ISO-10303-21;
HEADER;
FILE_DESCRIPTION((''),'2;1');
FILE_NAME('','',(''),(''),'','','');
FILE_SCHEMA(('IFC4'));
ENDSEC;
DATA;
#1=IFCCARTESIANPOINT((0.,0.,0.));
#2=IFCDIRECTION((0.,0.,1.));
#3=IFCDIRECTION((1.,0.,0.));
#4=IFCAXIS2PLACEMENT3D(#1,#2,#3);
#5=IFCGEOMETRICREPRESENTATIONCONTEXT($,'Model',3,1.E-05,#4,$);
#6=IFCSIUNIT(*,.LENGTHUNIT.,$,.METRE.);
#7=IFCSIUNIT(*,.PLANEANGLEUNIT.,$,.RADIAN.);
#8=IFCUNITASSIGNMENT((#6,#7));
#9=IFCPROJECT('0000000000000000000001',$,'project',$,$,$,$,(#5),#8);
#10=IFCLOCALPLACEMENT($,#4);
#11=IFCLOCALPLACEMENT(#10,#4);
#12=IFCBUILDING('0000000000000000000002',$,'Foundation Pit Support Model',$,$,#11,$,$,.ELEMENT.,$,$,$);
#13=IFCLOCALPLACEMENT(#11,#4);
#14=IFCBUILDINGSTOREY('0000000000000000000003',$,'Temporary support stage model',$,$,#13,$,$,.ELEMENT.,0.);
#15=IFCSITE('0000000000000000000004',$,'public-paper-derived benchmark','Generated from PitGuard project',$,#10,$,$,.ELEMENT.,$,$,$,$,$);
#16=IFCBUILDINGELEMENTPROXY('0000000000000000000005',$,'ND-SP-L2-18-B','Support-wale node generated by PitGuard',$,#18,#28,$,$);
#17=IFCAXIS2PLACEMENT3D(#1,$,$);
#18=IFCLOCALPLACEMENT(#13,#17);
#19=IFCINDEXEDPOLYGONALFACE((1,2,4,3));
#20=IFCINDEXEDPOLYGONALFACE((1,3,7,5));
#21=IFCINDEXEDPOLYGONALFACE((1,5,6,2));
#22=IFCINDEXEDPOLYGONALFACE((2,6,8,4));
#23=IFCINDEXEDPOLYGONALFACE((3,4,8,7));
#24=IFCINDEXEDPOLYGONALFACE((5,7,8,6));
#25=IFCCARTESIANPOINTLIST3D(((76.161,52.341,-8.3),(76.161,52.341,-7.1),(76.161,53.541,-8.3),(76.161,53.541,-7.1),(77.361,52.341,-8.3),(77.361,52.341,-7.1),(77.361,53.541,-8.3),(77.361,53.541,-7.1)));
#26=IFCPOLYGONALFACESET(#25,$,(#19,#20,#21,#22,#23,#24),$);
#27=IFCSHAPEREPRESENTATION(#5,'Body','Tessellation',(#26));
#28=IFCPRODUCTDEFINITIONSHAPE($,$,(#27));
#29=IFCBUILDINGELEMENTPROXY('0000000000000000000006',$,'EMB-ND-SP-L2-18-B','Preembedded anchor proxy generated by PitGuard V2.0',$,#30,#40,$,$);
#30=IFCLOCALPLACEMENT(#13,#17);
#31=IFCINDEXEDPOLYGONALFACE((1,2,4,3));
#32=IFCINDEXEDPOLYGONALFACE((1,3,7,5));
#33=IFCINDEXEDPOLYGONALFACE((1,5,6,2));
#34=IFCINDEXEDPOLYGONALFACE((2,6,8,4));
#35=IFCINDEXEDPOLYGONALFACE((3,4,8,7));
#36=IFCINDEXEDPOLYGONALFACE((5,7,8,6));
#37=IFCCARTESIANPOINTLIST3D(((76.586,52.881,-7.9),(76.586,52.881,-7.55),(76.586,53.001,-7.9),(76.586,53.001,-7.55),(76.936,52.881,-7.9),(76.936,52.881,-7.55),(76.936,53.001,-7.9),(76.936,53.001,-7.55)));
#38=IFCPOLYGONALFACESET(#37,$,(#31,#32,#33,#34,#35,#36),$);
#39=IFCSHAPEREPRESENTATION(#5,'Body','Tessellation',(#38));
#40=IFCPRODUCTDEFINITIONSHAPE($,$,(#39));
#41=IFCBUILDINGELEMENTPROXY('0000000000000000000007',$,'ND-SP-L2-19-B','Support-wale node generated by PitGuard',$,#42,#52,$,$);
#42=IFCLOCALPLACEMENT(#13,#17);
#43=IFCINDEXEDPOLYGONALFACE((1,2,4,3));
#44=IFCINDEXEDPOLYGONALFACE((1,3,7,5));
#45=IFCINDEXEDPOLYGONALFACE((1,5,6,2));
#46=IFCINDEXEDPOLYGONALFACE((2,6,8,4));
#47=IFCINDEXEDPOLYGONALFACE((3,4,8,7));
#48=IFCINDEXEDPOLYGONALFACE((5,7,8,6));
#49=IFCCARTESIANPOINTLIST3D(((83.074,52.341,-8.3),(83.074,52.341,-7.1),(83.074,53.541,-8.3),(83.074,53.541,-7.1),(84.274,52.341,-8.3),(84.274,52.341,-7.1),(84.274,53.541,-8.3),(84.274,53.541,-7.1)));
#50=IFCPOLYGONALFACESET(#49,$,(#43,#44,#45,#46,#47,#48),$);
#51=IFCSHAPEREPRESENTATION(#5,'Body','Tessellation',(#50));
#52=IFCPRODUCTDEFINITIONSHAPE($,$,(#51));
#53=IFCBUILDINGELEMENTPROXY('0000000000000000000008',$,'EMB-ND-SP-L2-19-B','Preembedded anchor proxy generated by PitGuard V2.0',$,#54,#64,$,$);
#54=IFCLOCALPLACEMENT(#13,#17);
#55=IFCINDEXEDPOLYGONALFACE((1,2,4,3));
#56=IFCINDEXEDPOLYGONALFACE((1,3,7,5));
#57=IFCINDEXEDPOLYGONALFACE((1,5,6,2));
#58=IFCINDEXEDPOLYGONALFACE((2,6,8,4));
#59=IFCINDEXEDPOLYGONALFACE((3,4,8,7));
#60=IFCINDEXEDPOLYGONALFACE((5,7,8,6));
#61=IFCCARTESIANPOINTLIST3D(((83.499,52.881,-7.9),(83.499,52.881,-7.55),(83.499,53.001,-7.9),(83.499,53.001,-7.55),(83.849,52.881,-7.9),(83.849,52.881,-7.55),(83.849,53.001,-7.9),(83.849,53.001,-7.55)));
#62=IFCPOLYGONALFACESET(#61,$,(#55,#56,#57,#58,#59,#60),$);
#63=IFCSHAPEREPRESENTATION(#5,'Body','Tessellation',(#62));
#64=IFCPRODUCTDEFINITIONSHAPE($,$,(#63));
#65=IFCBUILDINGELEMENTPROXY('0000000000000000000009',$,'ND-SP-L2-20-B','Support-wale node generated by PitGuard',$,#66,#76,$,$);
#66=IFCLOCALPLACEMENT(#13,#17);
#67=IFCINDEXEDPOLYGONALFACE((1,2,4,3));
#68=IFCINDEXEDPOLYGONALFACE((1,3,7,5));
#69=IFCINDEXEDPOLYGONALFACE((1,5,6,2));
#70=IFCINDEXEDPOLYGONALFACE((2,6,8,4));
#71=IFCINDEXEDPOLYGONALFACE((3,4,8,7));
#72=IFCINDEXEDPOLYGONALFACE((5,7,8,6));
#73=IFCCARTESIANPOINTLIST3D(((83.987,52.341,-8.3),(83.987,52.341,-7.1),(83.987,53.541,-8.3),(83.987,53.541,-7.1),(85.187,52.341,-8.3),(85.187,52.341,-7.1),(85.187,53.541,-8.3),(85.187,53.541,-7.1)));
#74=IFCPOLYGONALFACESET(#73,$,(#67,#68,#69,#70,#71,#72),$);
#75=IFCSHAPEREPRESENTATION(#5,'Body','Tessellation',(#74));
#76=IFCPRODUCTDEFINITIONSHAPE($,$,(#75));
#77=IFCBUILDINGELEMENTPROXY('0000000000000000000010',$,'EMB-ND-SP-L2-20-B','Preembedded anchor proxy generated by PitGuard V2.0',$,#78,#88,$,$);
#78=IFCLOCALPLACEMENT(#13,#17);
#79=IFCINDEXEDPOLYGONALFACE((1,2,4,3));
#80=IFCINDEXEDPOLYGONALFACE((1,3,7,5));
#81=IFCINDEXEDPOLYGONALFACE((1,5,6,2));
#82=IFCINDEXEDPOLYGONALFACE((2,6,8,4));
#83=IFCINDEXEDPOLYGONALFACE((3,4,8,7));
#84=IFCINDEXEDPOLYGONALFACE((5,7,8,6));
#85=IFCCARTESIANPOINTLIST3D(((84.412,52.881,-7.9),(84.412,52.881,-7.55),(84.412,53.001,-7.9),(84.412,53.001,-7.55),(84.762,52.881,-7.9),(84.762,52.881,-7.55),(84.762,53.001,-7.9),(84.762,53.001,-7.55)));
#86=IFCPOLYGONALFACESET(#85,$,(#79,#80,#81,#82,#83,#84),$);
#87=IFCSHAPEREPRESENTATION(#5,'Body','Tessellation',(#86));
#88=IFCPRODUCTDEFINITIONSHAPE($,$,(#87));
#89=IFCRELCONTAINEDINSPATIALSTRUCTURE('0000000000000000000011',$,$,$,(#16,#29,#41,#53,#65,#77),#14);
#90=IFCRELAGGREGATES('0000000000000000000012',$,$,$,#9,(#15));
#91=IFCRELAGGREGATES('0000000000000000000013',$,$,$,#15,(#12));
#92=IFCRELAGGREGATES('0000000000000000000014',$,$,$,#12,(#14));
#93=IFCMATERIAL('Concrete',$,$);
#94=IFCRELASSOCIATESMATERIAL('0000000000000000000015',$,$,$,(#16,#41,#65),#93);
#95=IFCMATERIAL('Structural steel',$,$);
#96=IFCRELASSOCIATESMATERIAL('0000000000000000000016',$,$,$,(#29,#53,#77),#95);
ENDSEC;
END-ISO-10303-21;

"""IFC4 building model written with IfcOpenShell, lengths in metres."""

from ifc_helpers import new_model, si_unit, frame, origin_with_axes, origin_2d, place, context, project, spatial, rectangle, extrude, material, element, save


model = new_model("IFC4")

# Units and contexts
model_context = context("Model", 3, precision=1e-05, world=origin_with_axes())
ifc_project = project(units=[si_unit("LENGTHUNIT", "METRE"), si_unit("PLANEANGLEUNIT", "RADIAN")], contexts=[model_context])

# Site, building, storey
site_placement = place(None, origin_with_axes())
site = spatial("IfcSite", under=ifc_project, at=site_placement, Name="public-paper-derived benchmark", Description="Generated from PitGuard project", CompositionType="ELEMENT")
building_placement = place(site_placement, origin_with_axes())
building = spatial("IfcBuilding", under=site, at=building_placement, Name="Foundation Pit Support Model", CompositionType="ELEMENT")
storey_placement = place(building_placement, origin_with_axes())
storey = spatial("IfcBuildingStorey", under=building, at=storey_placement, Name="Temporary support stage model", CompositionType="ELEMENT", Elevation=0.0)

# Shared definitions
ifc_material_1 = material(Name="Concrete")

# Shared definitions
ifc_material_2 = material(Name="Structural steel")

# Building element proxies
proxy_1_placement = place(storey_placement, frame((76.761, 52.941, -8.3), z_axis=(0.0, 0.0, 1.0), x_axis=(1.0, 0.0, 0.0)))
element("IfcBuildingElementProxy", 1, at=proxy_1_placement, inside=storey, material=ifc_material_1, Name="ND-SP-L2-18-B", Description="Support-wale node generated by PitGuard", context=model_context, shape_type="SweptSolid", body=[
    extrude(rectangle(XDim=1.2, YDim=1.2, at=origin_2d()), origin_with_axes(), (0.0, 0.0, 1.0), 1.2),
])
proxy_2_placement = place(storey_placement, frame((76.761, 52.941, -7.9), z_axis=(0.0, 0.0, 1.0), x_axis=(1.0, 0.0, 0.0)))
element("IfcBuildingElementProxy", 2, at=proxy_2_placement, inside=storey, material=ifc_material_2, Name="EMB-ND-SP-L2-18-B", Description="Preembedded anchor proxy generated by PitGuard V2.0", context=model_context, shape_type="SweptSolid", body=[
    extrude(rectangle(XDim=0.35, YDim=0.12, at=origin_2d()), origin_with_axes(), (0.0, 0.0, 1.0), 0.35),
])
proxy_3_placement = place(storey_placement, frame((83.674, 52.941, -8.3), z_axis=(0.0, 0.0, 1.0), x_axis=(1.0, 0.0, 0.0)))
element("IfcBuildingElementProxy", 3, at=proxy_3_placement, inside=storey, material=ifc_material_1, Name="ND-SP-L2-19-B", Description="Support-wale node generated by PitGuard", context=model_context, shape_type="SweptSolid", body=[
    extrude(rectangle(XDim=1.2, YDim=1.2, at=origin_2d()), origin_with_axes(), (0.0, 0.0, 1.0), 1.2),
])
proxy_4_placement = place(storey_placement, frame((83.674, 52.941, -7.9), z_axis=(0.0, 0.0, 1.0), x_axis=(1.0, 0.0, 0.0)))
element("IfcBuildingElementProxy", 4, at=proxy_4_placement, inside=storey, material=ifc_material_2, Name="EMB-ND-SP-L2-19-B", Description="Preembedded anchor proxy generated by PitGuard V2.0", context=model_context, shape_type="SweptSolid", body=[
    extrude(rectangle(XDim=0.35, YDim=0.12, at=origin_2d()), origin_with_axes(), (0.0, 0.0, 1.0), 0.35),
])
proxy_5_placement = place(storey_placement, frame((84.587, 52.941, -8.3), z_axis=(0.0, 0.0, 1.0), x_axis=(1.0, 0.0, 0.0)))
element("IfcBuildingElementProxy", 5, at=proxy_5_placement, inside=storey, material=ifc_material_1, Name="ND-SP-L2-20-B", Description="Support-wale node generated by PitGuard", context=model_context, shape_type="SweptSolid", body=[
    extrude(rectangle(XDim=1.2, YDim=1.2, at=origin_2d()), origin_with_axes(), (0.0, 0.0, 1.0), 1.2),
])
proxy_6_placement = place(storey_placement, frame((84.587, 52.941, -7.9), z_axis=(0.0, 0.0, 1.0), x_axis=(1.0, 0.0, 0.0)))
element("IfcBuildingElementProxy", 6, at=proxy_6_placement, inside=storey, material=ifc_material_2, Name="EMB-ND-SP-L2-20-B", Description="Preembedded anchor proxy generated by PitGuard V2.0", context=model_context, shape_type="SweptSolid", body=[
    extrude(rectangle(XDim=0.35, YDim=0.12, at=origin_2d()), origin_with_axes(), (0.0, 0.0, 1.0), 0.35),
])

save(model, "model.ifc")
